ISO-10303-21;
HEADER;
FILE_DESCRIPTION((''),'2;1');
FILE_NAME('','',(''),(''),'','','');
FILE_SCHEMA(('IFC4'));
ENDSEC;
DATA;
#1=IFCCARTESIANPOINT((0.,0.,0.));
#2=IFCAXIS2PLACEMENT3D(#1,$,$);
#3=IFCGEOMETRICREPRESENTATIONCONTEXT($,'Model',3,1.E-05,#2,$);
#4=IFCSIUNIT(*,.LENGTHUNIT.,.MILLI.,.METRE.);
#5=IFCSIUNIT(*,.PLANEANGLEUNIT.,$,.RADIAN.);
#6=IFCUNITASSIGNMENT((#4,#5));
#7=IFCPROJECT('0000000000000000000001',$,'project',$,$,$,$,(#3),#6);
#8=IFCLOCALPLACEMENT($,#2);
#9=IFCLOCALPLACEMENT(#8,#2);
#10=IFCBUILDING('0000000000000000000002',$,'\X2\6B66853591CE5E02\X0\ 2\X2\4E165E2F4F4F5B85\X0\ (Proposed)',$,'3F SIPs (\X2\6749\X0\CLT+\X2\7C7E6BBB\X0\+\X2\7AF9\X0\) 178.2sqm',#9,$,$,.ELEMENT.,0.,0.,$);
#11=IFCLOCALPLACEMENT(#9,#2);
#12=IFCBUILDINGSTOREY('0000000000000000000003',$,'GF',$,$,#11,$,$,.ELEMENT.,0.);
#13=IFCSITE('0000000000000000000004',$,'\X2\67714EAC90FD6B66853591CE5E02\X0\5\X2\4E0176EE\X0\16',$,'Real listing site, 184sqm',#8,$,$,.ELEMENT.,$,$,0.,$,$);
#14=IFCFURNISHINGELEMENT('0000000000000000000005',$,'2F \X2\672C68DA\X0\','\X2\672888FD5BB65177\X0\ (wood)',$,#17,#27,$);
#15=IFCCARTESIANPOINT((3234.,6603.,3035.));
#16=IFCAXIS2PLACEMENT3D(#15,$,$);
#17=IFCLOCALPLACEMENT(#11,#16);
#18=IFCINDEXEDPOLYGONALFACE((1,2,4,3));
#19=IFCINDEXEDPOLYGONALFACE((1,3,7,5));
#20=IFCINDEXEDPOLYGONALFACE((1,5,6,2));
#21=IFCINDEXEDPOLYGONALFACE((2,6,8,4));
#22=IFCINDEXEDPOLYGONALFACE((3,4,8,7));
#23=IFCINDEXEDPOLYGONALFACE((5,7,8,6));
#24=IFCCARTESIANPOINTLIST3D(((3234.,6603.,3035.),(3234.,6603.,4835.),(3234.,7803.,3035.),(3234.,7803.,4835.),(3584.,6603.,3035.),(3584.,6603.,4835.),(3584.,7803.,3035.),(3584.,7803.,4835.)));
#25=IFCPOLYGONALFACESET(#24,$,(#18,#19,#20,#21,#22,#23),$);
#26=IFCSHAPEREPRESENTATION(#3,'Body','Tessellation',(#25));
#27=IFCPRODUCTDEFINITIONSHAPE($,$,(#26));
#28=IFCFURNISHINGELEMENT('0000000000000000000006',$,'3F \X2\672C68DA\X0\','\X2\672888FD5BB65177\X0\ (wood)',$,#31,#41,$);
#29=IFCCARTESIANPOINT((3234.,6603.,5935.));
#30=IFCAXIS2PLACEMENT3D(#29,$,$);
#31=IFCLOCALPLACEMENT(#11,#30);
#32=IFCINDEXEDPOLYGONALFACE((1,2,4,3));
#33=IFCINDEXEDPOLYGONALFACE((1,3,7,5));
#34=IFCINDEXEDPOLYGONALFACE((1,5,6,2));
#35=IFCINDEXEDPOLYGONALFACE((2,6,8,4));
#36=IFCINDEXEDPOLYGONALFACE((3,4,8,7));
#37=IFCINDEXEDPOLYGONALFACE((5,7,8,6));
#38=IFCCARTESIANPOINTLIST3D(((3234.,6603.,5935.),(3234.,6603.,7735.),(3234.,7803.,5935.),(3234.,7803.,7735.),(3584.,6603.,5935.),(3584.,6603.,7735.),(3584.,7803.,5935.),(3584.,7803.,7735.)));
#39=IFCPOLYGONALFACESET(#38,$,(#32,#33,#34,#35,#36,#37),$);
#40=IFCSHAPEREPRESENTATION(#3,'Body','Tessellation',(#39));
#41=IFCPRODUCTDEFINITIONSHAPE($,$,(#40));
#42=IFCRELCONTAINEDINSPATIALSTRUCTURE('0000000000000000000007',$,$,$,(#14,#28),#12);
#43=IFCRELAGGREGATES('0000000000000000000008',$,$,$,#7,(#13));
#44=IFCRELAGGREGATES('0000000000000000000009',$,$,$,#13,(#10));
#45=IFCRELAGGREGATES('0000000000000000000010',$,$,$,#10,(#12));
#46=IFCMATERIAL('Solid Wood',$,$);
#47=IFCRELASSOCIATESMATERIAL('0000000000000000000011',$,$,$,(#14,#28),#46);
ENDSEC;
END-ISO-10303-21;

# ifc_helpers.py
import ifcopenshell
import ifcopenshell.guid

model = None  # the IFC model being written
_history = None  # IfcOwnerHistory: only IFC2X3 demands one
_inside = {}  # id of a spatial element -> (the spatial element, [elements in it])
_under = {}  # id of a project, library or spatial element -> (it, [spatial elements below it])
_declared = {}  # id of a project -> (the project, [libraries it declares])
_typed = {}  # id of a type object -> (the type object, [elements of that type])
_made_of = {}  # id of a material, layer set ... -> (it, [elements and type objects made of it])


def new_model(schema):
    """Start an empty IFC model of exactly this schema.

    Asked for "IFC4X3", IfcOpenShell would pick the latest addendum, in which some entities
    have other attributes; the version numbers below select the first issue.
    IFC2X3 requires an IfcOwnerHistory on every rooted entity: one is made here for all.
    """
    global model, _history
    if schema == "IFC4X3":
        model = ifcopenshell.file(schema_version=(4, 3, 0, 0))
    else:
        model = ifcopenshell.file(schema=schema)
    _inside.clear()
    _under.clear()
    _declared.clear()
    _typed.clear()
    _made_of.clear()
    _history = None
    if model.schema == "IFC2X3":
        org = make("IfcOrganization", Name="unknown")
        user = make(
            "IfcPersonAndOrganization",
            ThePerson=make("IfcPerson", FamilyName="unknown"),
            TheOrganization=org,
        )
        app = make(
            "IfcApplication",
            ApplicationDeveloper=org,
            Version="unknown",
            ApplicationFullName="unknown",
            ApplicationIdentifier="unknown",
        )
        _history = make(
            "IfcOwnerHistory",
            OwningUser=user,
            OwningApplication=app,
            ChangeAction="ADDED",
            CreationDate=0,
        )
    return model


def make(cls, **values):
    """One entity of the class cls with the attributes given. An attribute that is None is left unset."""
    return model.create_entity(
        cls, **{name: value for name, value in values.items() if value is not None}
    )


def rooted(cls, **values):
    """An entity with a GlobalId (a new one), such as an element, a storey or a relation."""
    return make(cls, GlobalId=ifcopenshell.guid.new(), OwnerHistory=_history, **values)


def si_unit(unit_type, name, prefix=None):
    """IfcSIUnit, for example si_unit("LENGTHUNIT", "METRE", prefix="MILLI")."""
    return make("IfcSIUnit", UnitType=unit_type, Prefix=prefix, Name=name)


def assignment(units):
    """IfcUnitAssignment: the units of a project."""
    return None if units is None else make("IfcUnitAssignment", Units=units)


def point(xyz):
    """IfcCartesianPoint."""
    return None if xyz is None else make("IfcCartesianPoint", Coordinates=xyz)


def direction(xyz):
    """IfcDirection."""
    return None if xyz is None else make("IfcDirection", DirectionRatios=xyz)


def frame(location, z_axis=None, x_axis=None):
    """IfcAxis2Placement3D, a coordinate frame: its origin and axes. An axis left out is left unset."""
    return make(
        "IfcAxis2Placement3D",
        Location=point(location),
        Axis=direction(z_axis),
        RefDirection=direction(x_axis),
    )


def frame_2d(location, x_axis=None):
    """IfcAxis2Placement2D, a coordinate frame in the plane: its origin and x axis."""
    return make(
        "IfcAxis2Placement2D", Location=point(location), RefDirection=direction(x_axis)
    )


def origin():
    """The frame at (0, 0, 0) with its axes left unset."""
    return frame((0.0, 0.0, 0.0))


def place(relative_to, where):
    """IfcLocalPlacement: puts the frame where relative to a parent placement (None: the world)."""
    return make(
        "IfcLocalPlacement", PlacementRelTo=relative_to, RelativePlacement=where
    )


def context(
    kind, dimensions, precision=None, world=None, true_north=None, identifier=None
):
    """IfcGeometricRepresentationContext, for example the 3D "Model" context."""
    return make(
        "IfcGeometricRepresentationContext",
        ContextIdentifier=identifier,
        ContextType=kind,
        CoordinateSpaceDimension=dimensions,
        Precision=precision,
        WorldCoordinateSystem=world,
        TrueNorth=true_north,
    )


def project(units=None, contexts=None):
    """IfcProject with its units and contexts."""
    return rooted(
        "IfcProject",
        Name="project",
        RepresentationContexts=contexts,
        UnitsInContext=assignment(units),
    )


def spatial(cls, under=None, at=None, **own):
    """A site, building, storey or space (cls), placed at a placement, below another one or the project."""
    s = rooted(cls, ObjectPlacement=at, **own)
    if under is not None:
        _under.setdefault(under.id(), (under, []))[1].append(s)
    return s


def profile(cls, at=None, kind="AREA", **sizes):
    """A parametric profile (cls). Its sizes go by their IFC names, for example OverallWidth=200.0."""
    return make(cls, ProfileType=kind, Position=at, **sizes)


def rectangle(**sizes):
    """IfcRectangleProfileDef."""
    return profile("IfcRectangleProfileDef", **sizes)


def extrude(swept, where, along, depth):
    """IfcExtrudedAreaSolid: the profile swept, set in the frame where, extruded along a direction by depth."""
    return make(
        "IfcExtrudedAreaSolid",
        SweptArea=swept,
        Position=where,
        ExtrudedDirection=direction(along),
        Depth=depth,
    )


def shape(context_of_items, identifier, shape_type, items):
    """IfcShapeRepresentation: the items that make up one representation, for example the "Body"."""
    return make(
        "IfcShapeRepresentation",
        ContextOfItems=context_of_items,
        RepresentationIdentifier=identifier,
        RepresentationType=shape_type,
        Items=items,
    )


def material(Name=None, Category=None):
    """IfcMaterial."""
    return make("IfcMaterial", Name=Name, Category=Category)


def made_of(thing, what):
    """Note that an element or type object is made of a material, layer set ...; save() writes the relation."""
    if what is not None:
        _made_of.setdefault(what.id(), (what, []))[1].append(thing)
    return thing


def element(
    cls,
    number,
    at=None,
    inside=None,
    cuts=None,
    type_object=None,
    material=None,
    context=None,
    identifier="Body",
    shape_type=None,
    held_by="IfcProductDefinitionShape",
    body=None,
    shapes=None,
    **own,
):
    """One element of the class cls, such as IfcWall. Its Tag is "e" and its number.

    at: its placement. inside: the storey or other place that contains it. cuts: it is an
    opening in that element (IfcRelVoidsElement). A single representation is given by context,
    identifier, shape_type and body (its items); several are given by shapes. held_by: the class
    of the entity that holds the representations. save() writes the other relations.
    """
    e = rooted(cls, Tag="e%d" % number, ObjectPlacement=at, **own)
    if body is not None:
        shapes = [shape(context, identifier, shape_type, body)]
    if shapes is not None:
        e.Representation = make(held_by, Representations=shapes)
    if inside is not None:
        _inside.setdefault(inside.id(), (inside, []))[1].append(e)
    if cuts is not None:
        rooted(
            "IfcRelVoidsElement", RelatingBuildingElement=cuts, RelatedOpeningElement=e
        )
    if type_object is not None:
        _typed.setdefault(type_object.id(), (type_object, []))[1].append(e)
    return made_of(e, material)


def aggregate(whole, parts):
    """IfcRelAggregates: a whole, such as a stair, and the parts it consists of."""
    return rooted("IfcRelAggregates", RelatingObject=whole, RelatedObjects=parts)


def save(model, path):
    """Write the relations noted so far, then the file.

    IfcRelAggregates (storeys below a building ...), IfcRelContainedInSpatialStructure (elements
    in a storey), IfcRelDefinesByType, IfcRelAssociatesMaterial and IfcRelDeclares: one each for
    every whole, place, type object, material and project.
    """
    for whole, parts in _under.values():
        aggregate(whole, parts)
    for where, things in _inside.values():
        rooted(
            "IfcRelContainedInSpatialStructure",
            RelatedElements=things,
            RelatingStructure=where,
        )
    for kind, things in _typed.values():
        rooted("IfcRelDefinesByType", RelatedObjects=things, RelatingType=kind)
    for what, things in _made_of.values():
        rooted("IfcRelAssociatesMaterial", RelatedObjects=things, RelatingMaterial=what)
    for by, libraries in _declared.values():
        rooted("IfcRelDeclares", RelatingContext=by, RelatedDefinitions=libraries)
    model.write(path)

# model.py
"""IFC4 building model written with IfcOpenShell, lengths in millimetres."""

from ifc_helpers import new_model, si_unit, frame, frame_2d, origin, place, context, project, spatial, rectangle, extrude, material, element, save


model = new_model("IFC4")

# Units and contexts
model_context = context("Model", 3, precision=1e-05, world=origin())
ifc_project = project(units=[si_unit("LENGTHUNIT", "METRE", prefix="MILLI"), si_unit("PLANEANGLEUNIT", "RADIAN")], contexts=[model_context])

# Site, building, storey
site_placement = place(None, origin())
site = spatial("IfcSite", under=ifc_project, at=site_placement, Name="東京都武蔵野市5丁目16", ObjectType="Real listing site, 184sqm", CompositionType="ELEMENT", RefElevation=0.0)
building_placement = place(site_placement, origin())
building = spatial("IfcBuilding", under=site, at=building_placement, Name="武蔵野市 2世帯住宅 (Proposed)", ObjectType="3F SIPs (杉CLT+籾殻+竹) 178.2sqm", CompositionType="ELEMENT", ElevationOfRefHeight=0.0, ElevationOfTerrain=0.0)
storey_placement = place(building_placement, origin())
storey = spatial("IfcBuildingStorey", under=building, at=storey_placement, Name="GF", CompositionType="ELEMENT", Elevation=0.0)

# Shared definitions
ifc_material_1 = material(Name="Solid Wood")

# Furnishing elements
furnishing_1_placement = place(storey_placement, frame((3234.0, 6603.0, 3035.0)))
element("IfcFurnishingElement", 1, at=furnishing_1_placement, inside=storey, material=ifc_material_1, Name="2F 本棚", Description="木製家具 (wood)", context=model_context, shape_type="SweptSolid", body=[
    extrude(rectangle(XDim=350.0, YDim=1200.0, at=frame_2d((175.0, 600.0))), frame((3234.0, 6603.0, 3035.0)), (0.0, 0.0, 1.0), 1800.0),
])
furnishing_2_placement = place(storey_placement, frame((3234.0, 6603.0, 5935.0)))
element("IfcFurnishingElement", 2, at=furnishing_2_placement, inside=storey, material=ifc_material_1, Name="3F 本棚", Description="木製家具 (wood)", context=model_context, shape_type="SweptSolid", body=[
    extrude(rectangle(XDim=350.0, YDim=1200.0, at=frame_2d((175.0, 600.0))), frame((3234.0, 6603.0, 5935.0)), (0.0, 0.0, 1.0), 1800.0),
])

save(model, "model.ifc")
